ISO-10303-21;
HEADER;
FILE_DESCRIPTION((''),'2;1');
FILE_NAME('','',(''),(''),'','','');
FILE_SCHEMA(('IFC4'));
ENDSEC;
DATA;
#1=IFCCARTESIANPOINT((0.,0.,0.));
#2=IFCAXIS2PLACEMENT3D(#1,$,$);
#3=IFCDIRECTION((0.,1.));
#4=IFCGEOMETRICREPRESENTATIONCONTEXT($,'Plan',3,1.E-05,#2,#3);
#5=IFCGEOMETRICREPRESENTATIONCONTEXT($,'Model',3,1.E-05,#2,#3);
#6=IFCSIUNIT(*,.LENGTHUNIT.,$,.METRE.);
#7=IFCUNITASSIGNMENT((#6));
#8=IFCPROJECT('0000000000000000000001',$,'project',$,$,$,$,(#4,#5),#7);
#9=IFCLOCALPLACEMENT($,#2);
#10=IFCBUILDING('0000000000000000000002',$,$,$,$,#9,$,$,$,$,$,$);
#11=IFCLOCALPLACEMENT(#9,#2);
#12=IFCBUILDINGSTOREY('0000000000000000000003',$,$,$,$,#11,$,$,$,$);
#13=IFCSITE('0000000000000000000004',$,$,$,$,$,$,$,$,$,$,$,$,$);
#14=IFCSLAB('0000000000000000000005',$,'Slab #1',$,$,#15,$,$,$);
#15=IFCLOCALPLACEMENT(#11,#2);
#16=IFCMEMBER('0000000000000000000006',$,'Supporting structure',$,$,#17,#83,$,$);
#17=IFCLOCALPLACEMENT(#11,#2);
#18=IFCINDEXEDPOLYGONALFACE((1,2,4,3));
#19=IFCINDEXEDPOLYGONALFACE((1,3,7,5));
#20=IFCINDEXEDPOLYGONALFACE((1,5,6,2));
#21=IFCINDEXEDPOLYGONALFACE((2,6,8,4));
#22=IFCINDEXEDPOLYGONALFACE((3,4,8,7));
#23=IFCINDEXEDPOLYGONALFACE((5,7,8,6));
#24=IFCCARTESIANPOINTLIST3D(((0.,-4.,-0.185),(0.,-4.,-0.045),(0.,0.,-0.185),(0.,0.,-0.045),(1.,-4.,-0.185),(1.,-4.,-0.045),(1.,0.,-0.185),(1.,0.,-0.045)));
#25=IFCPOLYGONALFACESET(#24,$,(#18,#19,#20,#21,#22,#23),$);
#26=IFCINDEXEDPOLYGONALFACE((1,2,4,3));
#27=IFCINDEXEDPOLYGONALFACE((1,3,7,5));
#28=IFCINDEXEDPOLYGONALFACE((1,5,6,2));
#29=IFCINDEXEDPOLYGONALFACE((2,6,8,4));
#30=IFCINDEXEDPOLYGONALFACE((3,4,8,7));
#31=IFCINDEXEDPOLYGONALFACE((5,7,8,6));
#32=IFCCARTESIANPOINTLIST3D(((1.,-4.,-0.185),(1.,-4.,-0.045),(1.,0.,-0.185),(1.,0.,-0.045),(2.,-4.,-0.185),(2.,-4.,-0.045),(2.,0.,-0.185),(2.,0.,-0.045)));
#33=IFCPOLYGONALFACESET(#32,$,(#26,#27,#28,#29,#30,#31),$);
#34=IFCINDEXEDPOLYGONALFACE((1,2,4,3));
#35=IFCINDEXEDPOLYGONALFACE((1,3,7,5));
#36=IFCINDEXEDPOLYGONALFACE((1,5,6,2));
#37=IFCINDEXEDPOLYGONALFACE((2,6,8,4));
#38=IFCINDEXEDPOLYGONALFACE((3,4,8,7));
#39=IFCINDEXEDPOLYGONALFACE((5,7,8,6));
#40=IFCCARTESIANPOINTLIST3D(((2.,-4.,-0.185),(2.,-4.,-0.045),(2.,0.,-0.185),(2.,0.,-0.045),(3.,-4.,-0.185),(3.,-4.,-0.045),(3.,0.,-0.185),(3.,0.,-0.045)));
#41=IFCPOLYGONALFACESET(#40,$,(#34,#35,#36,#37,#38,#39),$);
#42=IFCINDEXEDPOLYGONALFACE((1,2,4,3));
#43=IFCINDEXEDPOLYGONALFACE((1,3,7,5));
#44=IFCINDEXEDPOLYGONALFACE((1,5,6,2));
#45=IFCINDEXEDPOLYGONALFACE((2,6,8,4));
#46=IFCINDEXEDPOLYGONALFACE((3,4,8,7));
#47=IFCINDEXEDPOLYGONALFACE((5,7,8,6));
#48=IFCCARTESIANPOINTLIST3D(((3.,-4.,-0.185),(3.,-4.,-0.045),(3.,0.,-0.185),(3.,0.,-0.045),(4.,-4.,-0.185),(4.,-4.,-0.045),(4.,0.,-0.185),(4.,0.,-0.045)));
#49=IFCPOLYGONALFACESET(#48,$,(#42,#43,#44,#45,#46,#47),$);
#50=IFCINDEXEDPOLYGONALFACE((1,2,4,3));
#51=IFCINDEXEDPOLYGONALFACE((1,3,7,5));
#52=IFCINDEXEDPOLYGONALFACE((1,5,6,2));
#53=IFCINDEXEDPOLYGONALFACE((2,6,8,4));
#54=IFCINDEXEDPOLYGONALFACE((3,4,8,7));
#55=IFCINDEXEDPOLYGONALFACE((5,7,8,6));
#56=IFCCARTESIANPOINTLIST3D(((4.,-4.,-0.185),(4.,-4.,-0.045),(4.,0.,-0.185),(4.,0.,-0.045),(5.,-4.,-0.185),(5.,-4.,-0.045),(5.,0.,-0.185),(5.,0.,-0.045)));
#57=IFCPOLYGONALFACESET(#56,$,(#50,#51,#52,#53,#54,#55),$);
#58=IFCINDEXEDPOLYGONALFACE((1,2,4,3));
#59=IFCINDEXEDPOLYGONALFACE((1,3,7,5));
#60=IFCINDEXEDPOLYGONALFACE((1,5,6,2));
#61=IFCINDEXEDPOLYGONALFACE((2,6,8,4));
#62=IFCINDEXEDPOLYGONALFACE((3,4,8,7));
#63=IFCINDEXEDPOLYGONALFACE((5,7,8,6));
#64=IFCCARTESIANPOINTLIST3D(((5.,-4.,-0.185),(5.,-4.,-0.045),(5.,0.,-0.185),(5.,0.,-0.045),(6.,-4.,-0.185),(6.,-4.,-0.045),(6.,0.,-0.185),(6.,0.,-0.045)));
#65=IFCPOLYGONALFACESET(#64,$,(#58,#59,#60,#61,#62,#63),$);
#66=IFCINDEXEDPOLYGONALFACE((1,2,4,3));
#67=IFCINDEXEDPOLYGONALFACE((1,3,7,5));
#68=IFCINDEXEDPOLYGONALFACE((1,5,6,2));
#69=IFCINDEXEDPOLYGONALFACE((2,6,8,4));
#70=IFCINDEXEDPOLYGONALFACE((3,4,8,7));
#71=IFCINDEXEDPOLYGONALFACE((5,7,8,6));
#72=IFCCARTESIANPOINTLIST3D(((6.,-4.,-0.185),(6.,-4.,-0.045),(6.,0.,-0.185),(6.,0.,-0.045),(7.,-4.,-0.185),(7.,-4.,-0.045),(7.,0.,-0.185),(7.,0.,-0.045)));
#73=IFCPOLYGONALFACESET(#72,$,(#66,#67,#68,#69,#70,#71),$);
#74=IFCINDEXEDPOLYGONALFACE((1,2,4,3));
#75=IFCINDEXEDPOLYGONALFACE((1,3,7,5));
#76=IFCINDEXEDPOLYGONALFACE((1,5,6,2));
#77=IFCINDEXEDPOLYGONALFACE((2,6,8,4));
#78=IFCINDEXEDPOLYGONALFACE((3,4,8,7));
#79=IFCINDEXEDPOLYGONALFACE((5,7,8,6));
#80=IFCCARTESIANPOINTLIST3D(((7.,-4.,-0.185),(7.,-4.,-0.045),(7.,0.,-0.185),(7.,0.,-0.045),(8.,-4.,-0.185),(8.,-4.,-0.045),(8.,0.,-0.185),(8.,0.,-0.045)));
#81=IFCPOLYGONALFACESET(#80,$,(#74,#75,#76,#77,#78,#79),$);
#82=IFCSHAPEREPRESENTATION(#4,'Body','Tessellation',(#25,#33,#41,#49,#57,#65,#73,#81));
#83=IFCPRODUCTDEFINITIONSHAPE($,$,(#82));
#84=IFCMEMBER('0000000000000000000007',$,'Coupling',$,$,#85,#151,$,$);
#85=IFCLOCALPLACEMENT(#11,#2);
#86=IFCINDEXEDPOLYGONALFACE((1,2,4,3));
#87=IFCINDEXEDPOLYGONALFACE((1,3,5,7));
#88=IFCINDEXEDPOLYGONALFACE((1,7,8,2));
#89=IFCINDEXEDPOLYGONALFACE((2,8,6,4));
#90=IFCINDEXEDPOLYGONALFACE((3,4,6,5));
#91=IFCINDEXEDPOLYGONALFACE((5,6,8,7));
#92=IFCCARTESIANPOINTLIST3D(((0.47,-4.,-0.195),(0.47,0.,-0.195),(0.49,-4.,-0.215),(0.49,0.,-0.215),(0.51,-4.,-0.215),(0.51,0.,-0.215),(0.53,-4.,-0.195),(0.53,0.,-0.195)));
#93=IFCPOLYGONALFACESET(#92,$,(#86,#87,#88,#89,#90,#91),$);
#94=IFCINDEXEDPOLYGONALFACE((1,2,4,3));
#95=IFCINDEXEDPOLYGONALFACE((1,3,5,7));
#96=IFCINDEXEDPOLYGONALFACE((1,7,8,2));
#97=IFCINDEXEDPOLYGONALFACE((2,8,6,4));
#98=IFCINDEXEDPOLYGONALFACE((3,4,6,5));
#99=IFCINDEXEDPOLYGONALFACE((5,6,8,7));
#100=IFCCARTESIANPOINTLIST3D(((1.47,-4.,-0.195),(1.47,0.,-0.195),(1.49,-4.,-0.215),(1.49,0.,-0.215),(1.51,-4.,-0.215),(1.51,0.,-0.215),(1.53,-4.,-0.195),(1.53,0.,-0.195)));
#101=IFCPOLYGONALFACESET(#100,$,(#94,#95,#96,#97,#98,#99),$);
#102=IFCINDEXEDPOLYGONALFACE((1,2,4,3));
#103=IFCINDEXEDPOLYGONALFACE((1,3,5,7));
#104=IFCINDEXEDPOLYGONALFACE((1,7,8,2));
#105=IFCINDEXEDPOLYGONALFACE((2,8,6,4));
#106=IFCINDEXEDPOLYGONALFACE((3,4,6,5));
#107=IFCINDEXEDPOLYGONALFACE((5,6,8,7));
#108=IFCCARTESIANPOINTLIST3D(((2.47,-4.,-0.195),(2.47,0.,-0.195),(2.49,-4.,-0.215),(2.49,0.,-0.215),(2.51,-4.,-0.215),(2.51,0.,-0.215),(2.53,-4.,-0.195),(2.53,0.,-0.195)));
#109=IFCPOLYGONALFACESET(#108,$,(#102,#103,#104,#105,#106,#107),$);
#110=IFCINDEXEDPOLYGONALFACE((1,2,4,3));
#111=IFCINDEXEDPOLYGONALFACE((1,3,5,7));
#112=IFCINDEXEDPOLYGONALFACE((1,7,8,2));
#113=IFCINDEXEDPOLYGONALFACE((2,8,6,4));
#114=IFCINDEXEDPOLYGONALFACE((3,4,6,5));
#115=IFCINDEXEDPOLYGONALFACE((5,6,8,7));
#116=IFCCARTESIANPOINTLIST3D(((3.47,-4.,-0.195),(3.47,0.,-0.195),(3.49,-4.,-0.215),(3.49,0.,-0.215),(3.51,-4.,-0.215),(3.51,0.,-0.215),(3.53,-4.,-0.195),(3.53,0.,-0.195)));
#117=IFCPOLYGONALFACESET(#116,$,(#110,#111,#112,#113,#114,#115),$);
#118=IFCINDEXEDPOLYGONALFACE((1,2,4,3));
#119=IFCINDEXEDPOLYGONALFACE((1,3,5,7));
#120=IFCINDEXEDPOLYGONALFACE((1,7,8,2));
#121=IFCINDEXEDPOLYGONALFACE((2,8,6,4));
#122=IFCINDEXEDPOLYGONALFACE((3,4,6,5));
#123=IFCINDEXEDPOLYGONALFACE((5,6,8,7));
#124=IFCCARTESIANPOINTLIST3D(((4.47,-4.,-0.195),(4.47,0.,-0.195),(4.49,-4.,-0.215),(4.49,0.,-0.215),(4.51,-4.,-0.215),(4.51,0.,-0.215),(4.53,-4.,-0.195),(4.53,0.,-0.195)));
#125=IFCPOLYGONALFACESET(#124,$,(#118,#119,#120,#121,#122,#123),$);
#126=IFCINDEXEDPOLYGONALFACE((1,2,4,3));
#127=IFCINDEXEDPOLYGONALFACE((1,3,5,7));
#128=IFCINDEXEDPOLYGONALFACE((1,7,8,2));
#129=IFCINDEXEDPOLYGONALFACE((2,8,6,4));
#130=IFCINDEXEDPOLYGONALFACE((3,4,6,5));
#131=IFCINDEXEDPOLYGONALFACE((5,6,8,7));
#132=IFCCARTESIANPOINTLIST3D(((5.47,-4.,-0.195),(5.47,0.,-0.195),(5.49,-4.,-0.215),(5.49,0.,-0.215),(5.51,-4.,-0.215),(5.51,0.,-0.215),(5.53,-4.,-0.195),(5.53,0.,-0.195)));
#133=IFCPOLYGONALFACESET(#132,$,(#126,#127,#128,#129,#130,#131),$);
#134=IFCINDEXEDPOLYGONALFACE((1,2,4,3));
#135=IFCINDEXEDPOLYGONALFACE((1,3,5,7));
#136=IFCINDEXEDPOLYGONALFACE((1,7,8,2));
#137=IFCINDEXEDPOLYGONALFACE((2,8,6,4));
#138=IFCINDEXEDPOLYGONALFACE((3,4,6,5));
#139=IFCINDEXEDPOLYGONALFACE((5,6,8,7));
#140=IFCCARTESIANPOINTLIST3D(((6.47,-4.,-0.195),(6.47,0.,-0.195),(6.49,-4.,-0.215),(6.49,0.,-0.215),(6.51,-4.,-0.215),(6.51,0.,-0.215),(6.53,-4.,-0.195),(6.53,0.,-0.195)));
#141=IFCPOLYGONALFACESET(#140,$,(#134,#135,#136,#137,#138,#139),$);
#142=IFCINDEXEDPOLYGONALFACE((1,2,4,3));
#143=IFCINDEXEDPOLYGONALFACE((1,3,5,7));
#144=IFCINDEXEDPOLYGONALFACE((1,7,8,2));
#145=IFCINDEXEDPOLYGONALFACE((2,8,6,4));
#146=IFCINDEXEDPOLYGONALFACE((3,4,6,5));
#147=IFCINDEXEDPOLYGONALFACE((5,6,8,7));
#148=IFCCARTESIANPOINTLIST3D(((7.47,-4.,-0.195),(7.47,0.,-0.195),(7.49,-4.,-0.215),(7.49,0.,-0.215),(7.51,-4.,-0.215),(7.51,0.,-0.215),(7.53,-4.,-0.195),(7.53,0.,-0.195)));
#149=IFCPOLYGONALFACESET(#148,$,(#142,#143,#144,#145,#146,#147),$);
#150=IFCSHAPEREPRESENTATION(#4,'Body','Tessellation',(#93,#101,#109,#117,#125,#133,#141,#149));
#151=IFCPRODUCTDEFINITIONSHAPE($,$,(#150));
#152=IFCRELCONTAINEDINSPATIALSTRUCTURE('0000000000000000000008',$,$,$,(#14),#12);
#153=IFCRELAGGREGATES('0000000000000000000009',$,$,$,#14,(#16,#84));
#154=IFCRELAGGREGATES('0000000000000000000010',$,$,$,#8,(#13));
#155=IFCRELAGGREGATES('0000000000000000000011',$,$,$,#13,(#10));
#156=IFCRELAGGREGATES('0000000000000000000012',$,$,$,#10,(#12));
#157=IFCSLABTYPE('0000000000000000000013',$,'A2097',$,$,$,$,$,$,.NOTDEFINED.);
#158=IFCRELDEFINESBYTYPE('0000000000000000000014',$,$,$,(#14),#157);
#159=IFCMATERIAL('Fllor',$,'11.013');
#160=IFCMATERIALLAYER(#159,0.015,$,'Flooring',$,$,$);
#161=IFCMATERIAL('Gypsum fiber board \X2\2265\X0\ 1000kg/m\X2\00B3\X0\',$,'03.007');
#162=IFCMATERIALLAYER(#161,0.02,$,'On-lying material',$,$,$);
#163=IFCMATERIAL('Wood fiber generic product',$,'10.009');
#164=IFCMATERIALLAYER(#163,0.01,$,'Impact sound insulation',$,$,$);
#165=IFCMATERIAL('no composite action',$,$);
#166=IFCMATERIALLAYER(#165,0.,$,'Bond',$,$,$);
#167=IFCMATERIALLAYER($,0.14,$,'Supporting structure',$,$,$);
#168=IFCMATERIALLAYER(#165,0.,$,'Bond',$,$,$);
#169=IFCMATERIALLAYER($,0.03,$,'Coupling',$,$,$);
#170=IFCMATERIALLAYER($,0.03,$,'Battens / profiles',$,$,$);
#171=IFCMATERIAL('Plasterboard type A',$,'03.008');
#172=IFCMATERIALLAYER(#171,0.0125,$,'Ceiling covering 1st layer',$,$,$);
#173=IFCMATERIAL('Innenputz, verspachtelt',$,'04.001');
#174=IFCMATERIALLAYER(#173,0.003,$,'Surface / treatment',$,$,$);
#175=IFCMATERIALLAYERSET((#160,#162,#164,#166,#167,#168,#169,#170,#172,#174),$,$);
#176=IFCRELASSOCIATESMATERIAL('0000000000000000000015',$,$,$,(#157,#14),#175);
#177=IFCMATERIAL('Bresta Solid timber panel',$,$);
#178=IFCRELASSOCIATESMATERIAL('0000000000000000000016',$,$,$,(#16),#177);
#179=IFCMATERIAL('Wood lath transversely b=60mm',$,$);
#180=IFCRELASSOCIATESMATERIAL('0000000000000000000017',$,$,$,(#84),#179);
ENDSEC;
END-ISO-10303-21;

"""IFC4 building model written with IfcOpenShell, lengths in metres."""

from ifc_helpers import new_model, si_unit, direction, frame, frame_2d, origin, place, context, project, spatial, polyline, rectangle, outline, extrude, material, layer, layer_set, type_object, element, aggregate, save


model = new_model("IFC4")

# Units and contexts
plan_context = context("Plan", 3, precision=1e-05, world=origin(), true_north=direction((0.0, 1.0)))
model_context = context("Model", 3, precision=1e-05, world=origin(), true_north=direction((0.0, 1.0)))
ifc_project = project(units=[si_unit("LENGTHUNIT", "METRE")], contexts=[plan_context, model_context])

# Site, building, storey
site = spatial("IfcSite", under=ifc_project)
building_placement = place(None, origin())
building = spatial("IfcBuilding", under=site, at=building_placement)
storey_placement = place(building_placement, origin())
storey = spatial("IfcBuildingStorey", under=building, at=storey_placement)

# Slab, members
ifc_material_1 = material(Name="Fllor", Category="11.013")
ifc_layer_1 = layer(ifc_material_1, 0.015, Name="Flooring")
ifc_material_2 = material(Name="Gypsum fiber board ≥ 1000kg/m³", Category="03.007")
ifc_layer_2 = layer(ifc_material_2, 0.02, Name="On-lying material")
ifc_material_3 = material(Name="Wood fiber generic product", Category="10.009")
ifc_layer_3 = layer(ifc_material_3, 0.01, Name="Impact sound insulation")
ifc_material_4 = material(Name="no composite action")
ifc_layer_4 = layer(ifc_material_4, 0.0, Name="Bond")
ifc_layer_5 = layer(None, 0.14, Name="Supporting structure")
ifc_layer_6 = layer(ifc_material_4, 0.0, Name="Bond")
ifc_layer_7 = layer(None, 0.03, Name="Coupling")
ifc_layer_8 = layer(None, 0.03, Name="Battens / profiles")
ifc_material_5 = material(Name="Plasterboard type A", Category="03.008")
ifc_layer_9 = layer(ifc_material_5, 0.0125, Name="Ceiling covering 1st layer")
ifc_material_6 = material(Name="Innenputz, verspachtelt", Category="04.001")
ifc_layer_10 = layer(ifc_material_6, 0.003, Name="Surface / treatment")
ifc_layer_set = layer_set([ifc_layer_1, ifc_layer_2, ifc_layer_3, ifc_layer_4, ifc_layer_5, ifc_layer_6, ifc_layer_7, ifc_layer_8, ifc_layer_9, ifc_layer_10])
slab_type = type_object("IfcSlabType", Name="A2097", PredefinedType="NOTDEFINED", material=ifc_layer_set)
slab_placement = place(None, frame((0.0, 0.0, 0.0), z_axis=(0.0, 0.0, -1.0), x_axis=(1.0, 0.0, 0.0)))
slab = element("IfcSlab", 1, at=slab_placement, inside=storey, type_object=slab_type, material=ifc_layer_set, Name="Slab #1")
ifc_material_7 = material(Name="Bresta Solid timber panel")
member_1_placement = place(slab_placement, origin())
member_1 = element("IfcMember", 2, at=member_1_placement, material=ifc_material_7, Name="Supporting structure", context=plan_context, shape_type="SweptSolid", body=[
    extrude(rectangle(XDim=1.0, YDim=0.14, at=frame_2d((0.5, 0.07), x_axis=(1.0, 0.0))), frame((0.0, 4.0, 0.045), z_axis=(0.0, -1.0, 0.0), x_axis=(1.0, 0.0, 0.0)), (0.0, 0.0, 1.0), 4.0),
    extrude(rectangle(XDim=1.0, YDim=0.14, at=frame_2d((0.5, 0.07), x_axis=(1.0, 0.0))), frame((1.0, 4.0, 0.045), z_axis=(0.0, -1.0, 0.0), x_axis=(1.0, 0.0, 0.0)), (0.0, 0.0, 1.0), 4.0),
    extrude(rectangle(XDim=1.0, YDim=0.14, at=frame_2d((0.5, 0.07), x_axis=(1.0, 0.0))), frame((2.0, 4.0, 0.045), z_axis=(0.0, -1.0, 0.0), x_axis=(1.0, 0.0, 0.0)), (0.0, 0.0, 1.0), 4.0),
    extrude(rectangle(XDim=1.0, YDim=0.14, at=frame_2d((0.5, 0.07), x_axis=(1.0, 0.0))), frame((3.0, 4.0, 0.045), z_axis=(0.0, -1.0, 0.0), x_axis=(1.0, 0.0, 0.0)), (0.0, 0.0, 1.0), 4.0),
    extrude(rectangle(XDim=1.0, YDim=0.14, at=frame_2d((0.5, 0.07), x_axis=(1.0, 0.0))), frame((4.0, 4.0, 0.045), z_axis=(0.0, -1.0, 0.0), x_axis=(1.0, 0.0, 0.0)), (0.0, 0.0, 1.0), 4.0),
    extrude(rectangle(XDim=1.0, YDim=0.14, at=frame_2d((0.5, 0.07), x_axis=(1.0, 0.0))), frame((5.0, 4.0, 0.045), z_axis=(0.0, -1.0, 0.0), x_axis=(1.0, 0.0, 0.0)), (0.0, 0.0, 1.0), 4.0),
    extrude(rectangle(XDim=1.0, YDim=0.14, at=frame_2d((0.5, 0.07), x_axis=(1.0, 0.0))), frame((6.0, 4.0, 0.045), z_axis=(0.0, -1.0, 0.0), x_axis=(1.0, 0.0, 0.0)), (0.0, 0.0, 1.0), 4.0),
    extrude(rectangle(XDim=1.0, YDim=0.14, at=frame_2d((0.5, 0.07), x_axis=(1.0, 0.0))), frame((7.0, 4.0, 0.045), z_axis=(0.0, -1.0, 0.0), x_axis=(1.0, 0.0, 0.0)), (0.0, 0.0, 1.0), 4.0),
])
ifc_material_8 = material(Name="Wood lath transversely b=60mm")
member_2_placement = place(slab_placement, origin())
member_2 = element("IfcMember", 3, at=member_2_placement, material=ifc_material_8, Name="Coupling", context=plan_context, shape_type="SweptSolid", body=[
    extrude(outline(polyline([(0.0, 0.0), (0.06, 0.0), (0.04, 0.02), (0.02, 0.02), (0.0, 0.0)])), frame((0.47, 4.0, 0.195), z_axis=(0.0, -1.0, 0.0), x_axis=(1.0, 0.0, 0.0)), (0.0, 0.0, 1.0), 4.0),
    extrude(outline(polyline([(0.0, 0.0), (0.06, 0.0), (0.04, 0.02), (0.02, 0.02), (0.0, 0.0)])), frame((1.47, 4.0, 0.195), z_axis=(0.0, -1.0, 0.0), x_axis=(1.0, 0.0, 0.0)), (0.0, 0.0, 1.0), 4.0),
    extrude(outline(polyline([(0.0, 0.0), (0.06, 0.0), (0.04, 0.02), (0.02, 0.02), (0.0, 0.0)])), frame((2.47, 4.0, 0.195), z_axis=(0.0, -1.0, 0.0), x_axis=(1.0, 0.0, 0.0)), (0.0, 0.0, 1.0), 4.0),
    extrude(outline(polyline([(0.0, 0.0), (0.06, 0.0), (0.04, 0.02), (0.02, 0.02), (0.0, 0.0)])), frame((3.47, 4.0, 0.195), z_axis=(0.0, -1.0, 0.0), x_axis=(1.0, 0.0, 0.0)), (0.0, 0.0, 1.0), 4.0),
    extrude(outline(polyline([(0.0, 0.0), (0.06, 0.0), (0.04, 0.02), (0.02, 0.02), (0.0, 0.0)])), frame((4.47, 4.0, 0.195), z_axis=(0.0, -1.0, 0.0), x_axis=(1.0, 0.0, 0.0)), (0.0, 0.0, 1.0), 4.0),
    extrude(outline(polyline([(0.0, 0.0), (0.06, 0.0), (0.04, 0.02), (0.02, 0.02), (0.0, 0.0)])), frame((5.47, 4.0, 0.195), z_axis=(0.0, -1.0, 0.0), x_axis=(1.0, 0.0, 0.0)), (0.0, 0.0, 1.0), 4.0),
    extrude(outline(polyline([(0.0, 0.0), (0.06, 0.0), (0.04, 0.02), (0.02, 0.02), (0.0, 0.0)])), frame((6.47, 4.0, 0.195), z_axis=(0.0, -1.0, 0.0), x_axis=(1.0, 0.0, 0.0)), (0.0, 0.0, 1.0), 4.0),
    extrude(outline(polyline([(0.0, 0.0), (0.06, 0.0), (0.04, 0.02), (0.02, 0.02), (0.0, 0.0)])), frame((7.47, 4.0, 0.195), z_axis=(0.0, -1.0, 0.0), x_axis=(1.0, 0.0, 0.0)), (0.0, 0.0, 1.0), 4.0),
])
aggregate(slab, [member_1, member_2])

save(model, "model.ifc")
